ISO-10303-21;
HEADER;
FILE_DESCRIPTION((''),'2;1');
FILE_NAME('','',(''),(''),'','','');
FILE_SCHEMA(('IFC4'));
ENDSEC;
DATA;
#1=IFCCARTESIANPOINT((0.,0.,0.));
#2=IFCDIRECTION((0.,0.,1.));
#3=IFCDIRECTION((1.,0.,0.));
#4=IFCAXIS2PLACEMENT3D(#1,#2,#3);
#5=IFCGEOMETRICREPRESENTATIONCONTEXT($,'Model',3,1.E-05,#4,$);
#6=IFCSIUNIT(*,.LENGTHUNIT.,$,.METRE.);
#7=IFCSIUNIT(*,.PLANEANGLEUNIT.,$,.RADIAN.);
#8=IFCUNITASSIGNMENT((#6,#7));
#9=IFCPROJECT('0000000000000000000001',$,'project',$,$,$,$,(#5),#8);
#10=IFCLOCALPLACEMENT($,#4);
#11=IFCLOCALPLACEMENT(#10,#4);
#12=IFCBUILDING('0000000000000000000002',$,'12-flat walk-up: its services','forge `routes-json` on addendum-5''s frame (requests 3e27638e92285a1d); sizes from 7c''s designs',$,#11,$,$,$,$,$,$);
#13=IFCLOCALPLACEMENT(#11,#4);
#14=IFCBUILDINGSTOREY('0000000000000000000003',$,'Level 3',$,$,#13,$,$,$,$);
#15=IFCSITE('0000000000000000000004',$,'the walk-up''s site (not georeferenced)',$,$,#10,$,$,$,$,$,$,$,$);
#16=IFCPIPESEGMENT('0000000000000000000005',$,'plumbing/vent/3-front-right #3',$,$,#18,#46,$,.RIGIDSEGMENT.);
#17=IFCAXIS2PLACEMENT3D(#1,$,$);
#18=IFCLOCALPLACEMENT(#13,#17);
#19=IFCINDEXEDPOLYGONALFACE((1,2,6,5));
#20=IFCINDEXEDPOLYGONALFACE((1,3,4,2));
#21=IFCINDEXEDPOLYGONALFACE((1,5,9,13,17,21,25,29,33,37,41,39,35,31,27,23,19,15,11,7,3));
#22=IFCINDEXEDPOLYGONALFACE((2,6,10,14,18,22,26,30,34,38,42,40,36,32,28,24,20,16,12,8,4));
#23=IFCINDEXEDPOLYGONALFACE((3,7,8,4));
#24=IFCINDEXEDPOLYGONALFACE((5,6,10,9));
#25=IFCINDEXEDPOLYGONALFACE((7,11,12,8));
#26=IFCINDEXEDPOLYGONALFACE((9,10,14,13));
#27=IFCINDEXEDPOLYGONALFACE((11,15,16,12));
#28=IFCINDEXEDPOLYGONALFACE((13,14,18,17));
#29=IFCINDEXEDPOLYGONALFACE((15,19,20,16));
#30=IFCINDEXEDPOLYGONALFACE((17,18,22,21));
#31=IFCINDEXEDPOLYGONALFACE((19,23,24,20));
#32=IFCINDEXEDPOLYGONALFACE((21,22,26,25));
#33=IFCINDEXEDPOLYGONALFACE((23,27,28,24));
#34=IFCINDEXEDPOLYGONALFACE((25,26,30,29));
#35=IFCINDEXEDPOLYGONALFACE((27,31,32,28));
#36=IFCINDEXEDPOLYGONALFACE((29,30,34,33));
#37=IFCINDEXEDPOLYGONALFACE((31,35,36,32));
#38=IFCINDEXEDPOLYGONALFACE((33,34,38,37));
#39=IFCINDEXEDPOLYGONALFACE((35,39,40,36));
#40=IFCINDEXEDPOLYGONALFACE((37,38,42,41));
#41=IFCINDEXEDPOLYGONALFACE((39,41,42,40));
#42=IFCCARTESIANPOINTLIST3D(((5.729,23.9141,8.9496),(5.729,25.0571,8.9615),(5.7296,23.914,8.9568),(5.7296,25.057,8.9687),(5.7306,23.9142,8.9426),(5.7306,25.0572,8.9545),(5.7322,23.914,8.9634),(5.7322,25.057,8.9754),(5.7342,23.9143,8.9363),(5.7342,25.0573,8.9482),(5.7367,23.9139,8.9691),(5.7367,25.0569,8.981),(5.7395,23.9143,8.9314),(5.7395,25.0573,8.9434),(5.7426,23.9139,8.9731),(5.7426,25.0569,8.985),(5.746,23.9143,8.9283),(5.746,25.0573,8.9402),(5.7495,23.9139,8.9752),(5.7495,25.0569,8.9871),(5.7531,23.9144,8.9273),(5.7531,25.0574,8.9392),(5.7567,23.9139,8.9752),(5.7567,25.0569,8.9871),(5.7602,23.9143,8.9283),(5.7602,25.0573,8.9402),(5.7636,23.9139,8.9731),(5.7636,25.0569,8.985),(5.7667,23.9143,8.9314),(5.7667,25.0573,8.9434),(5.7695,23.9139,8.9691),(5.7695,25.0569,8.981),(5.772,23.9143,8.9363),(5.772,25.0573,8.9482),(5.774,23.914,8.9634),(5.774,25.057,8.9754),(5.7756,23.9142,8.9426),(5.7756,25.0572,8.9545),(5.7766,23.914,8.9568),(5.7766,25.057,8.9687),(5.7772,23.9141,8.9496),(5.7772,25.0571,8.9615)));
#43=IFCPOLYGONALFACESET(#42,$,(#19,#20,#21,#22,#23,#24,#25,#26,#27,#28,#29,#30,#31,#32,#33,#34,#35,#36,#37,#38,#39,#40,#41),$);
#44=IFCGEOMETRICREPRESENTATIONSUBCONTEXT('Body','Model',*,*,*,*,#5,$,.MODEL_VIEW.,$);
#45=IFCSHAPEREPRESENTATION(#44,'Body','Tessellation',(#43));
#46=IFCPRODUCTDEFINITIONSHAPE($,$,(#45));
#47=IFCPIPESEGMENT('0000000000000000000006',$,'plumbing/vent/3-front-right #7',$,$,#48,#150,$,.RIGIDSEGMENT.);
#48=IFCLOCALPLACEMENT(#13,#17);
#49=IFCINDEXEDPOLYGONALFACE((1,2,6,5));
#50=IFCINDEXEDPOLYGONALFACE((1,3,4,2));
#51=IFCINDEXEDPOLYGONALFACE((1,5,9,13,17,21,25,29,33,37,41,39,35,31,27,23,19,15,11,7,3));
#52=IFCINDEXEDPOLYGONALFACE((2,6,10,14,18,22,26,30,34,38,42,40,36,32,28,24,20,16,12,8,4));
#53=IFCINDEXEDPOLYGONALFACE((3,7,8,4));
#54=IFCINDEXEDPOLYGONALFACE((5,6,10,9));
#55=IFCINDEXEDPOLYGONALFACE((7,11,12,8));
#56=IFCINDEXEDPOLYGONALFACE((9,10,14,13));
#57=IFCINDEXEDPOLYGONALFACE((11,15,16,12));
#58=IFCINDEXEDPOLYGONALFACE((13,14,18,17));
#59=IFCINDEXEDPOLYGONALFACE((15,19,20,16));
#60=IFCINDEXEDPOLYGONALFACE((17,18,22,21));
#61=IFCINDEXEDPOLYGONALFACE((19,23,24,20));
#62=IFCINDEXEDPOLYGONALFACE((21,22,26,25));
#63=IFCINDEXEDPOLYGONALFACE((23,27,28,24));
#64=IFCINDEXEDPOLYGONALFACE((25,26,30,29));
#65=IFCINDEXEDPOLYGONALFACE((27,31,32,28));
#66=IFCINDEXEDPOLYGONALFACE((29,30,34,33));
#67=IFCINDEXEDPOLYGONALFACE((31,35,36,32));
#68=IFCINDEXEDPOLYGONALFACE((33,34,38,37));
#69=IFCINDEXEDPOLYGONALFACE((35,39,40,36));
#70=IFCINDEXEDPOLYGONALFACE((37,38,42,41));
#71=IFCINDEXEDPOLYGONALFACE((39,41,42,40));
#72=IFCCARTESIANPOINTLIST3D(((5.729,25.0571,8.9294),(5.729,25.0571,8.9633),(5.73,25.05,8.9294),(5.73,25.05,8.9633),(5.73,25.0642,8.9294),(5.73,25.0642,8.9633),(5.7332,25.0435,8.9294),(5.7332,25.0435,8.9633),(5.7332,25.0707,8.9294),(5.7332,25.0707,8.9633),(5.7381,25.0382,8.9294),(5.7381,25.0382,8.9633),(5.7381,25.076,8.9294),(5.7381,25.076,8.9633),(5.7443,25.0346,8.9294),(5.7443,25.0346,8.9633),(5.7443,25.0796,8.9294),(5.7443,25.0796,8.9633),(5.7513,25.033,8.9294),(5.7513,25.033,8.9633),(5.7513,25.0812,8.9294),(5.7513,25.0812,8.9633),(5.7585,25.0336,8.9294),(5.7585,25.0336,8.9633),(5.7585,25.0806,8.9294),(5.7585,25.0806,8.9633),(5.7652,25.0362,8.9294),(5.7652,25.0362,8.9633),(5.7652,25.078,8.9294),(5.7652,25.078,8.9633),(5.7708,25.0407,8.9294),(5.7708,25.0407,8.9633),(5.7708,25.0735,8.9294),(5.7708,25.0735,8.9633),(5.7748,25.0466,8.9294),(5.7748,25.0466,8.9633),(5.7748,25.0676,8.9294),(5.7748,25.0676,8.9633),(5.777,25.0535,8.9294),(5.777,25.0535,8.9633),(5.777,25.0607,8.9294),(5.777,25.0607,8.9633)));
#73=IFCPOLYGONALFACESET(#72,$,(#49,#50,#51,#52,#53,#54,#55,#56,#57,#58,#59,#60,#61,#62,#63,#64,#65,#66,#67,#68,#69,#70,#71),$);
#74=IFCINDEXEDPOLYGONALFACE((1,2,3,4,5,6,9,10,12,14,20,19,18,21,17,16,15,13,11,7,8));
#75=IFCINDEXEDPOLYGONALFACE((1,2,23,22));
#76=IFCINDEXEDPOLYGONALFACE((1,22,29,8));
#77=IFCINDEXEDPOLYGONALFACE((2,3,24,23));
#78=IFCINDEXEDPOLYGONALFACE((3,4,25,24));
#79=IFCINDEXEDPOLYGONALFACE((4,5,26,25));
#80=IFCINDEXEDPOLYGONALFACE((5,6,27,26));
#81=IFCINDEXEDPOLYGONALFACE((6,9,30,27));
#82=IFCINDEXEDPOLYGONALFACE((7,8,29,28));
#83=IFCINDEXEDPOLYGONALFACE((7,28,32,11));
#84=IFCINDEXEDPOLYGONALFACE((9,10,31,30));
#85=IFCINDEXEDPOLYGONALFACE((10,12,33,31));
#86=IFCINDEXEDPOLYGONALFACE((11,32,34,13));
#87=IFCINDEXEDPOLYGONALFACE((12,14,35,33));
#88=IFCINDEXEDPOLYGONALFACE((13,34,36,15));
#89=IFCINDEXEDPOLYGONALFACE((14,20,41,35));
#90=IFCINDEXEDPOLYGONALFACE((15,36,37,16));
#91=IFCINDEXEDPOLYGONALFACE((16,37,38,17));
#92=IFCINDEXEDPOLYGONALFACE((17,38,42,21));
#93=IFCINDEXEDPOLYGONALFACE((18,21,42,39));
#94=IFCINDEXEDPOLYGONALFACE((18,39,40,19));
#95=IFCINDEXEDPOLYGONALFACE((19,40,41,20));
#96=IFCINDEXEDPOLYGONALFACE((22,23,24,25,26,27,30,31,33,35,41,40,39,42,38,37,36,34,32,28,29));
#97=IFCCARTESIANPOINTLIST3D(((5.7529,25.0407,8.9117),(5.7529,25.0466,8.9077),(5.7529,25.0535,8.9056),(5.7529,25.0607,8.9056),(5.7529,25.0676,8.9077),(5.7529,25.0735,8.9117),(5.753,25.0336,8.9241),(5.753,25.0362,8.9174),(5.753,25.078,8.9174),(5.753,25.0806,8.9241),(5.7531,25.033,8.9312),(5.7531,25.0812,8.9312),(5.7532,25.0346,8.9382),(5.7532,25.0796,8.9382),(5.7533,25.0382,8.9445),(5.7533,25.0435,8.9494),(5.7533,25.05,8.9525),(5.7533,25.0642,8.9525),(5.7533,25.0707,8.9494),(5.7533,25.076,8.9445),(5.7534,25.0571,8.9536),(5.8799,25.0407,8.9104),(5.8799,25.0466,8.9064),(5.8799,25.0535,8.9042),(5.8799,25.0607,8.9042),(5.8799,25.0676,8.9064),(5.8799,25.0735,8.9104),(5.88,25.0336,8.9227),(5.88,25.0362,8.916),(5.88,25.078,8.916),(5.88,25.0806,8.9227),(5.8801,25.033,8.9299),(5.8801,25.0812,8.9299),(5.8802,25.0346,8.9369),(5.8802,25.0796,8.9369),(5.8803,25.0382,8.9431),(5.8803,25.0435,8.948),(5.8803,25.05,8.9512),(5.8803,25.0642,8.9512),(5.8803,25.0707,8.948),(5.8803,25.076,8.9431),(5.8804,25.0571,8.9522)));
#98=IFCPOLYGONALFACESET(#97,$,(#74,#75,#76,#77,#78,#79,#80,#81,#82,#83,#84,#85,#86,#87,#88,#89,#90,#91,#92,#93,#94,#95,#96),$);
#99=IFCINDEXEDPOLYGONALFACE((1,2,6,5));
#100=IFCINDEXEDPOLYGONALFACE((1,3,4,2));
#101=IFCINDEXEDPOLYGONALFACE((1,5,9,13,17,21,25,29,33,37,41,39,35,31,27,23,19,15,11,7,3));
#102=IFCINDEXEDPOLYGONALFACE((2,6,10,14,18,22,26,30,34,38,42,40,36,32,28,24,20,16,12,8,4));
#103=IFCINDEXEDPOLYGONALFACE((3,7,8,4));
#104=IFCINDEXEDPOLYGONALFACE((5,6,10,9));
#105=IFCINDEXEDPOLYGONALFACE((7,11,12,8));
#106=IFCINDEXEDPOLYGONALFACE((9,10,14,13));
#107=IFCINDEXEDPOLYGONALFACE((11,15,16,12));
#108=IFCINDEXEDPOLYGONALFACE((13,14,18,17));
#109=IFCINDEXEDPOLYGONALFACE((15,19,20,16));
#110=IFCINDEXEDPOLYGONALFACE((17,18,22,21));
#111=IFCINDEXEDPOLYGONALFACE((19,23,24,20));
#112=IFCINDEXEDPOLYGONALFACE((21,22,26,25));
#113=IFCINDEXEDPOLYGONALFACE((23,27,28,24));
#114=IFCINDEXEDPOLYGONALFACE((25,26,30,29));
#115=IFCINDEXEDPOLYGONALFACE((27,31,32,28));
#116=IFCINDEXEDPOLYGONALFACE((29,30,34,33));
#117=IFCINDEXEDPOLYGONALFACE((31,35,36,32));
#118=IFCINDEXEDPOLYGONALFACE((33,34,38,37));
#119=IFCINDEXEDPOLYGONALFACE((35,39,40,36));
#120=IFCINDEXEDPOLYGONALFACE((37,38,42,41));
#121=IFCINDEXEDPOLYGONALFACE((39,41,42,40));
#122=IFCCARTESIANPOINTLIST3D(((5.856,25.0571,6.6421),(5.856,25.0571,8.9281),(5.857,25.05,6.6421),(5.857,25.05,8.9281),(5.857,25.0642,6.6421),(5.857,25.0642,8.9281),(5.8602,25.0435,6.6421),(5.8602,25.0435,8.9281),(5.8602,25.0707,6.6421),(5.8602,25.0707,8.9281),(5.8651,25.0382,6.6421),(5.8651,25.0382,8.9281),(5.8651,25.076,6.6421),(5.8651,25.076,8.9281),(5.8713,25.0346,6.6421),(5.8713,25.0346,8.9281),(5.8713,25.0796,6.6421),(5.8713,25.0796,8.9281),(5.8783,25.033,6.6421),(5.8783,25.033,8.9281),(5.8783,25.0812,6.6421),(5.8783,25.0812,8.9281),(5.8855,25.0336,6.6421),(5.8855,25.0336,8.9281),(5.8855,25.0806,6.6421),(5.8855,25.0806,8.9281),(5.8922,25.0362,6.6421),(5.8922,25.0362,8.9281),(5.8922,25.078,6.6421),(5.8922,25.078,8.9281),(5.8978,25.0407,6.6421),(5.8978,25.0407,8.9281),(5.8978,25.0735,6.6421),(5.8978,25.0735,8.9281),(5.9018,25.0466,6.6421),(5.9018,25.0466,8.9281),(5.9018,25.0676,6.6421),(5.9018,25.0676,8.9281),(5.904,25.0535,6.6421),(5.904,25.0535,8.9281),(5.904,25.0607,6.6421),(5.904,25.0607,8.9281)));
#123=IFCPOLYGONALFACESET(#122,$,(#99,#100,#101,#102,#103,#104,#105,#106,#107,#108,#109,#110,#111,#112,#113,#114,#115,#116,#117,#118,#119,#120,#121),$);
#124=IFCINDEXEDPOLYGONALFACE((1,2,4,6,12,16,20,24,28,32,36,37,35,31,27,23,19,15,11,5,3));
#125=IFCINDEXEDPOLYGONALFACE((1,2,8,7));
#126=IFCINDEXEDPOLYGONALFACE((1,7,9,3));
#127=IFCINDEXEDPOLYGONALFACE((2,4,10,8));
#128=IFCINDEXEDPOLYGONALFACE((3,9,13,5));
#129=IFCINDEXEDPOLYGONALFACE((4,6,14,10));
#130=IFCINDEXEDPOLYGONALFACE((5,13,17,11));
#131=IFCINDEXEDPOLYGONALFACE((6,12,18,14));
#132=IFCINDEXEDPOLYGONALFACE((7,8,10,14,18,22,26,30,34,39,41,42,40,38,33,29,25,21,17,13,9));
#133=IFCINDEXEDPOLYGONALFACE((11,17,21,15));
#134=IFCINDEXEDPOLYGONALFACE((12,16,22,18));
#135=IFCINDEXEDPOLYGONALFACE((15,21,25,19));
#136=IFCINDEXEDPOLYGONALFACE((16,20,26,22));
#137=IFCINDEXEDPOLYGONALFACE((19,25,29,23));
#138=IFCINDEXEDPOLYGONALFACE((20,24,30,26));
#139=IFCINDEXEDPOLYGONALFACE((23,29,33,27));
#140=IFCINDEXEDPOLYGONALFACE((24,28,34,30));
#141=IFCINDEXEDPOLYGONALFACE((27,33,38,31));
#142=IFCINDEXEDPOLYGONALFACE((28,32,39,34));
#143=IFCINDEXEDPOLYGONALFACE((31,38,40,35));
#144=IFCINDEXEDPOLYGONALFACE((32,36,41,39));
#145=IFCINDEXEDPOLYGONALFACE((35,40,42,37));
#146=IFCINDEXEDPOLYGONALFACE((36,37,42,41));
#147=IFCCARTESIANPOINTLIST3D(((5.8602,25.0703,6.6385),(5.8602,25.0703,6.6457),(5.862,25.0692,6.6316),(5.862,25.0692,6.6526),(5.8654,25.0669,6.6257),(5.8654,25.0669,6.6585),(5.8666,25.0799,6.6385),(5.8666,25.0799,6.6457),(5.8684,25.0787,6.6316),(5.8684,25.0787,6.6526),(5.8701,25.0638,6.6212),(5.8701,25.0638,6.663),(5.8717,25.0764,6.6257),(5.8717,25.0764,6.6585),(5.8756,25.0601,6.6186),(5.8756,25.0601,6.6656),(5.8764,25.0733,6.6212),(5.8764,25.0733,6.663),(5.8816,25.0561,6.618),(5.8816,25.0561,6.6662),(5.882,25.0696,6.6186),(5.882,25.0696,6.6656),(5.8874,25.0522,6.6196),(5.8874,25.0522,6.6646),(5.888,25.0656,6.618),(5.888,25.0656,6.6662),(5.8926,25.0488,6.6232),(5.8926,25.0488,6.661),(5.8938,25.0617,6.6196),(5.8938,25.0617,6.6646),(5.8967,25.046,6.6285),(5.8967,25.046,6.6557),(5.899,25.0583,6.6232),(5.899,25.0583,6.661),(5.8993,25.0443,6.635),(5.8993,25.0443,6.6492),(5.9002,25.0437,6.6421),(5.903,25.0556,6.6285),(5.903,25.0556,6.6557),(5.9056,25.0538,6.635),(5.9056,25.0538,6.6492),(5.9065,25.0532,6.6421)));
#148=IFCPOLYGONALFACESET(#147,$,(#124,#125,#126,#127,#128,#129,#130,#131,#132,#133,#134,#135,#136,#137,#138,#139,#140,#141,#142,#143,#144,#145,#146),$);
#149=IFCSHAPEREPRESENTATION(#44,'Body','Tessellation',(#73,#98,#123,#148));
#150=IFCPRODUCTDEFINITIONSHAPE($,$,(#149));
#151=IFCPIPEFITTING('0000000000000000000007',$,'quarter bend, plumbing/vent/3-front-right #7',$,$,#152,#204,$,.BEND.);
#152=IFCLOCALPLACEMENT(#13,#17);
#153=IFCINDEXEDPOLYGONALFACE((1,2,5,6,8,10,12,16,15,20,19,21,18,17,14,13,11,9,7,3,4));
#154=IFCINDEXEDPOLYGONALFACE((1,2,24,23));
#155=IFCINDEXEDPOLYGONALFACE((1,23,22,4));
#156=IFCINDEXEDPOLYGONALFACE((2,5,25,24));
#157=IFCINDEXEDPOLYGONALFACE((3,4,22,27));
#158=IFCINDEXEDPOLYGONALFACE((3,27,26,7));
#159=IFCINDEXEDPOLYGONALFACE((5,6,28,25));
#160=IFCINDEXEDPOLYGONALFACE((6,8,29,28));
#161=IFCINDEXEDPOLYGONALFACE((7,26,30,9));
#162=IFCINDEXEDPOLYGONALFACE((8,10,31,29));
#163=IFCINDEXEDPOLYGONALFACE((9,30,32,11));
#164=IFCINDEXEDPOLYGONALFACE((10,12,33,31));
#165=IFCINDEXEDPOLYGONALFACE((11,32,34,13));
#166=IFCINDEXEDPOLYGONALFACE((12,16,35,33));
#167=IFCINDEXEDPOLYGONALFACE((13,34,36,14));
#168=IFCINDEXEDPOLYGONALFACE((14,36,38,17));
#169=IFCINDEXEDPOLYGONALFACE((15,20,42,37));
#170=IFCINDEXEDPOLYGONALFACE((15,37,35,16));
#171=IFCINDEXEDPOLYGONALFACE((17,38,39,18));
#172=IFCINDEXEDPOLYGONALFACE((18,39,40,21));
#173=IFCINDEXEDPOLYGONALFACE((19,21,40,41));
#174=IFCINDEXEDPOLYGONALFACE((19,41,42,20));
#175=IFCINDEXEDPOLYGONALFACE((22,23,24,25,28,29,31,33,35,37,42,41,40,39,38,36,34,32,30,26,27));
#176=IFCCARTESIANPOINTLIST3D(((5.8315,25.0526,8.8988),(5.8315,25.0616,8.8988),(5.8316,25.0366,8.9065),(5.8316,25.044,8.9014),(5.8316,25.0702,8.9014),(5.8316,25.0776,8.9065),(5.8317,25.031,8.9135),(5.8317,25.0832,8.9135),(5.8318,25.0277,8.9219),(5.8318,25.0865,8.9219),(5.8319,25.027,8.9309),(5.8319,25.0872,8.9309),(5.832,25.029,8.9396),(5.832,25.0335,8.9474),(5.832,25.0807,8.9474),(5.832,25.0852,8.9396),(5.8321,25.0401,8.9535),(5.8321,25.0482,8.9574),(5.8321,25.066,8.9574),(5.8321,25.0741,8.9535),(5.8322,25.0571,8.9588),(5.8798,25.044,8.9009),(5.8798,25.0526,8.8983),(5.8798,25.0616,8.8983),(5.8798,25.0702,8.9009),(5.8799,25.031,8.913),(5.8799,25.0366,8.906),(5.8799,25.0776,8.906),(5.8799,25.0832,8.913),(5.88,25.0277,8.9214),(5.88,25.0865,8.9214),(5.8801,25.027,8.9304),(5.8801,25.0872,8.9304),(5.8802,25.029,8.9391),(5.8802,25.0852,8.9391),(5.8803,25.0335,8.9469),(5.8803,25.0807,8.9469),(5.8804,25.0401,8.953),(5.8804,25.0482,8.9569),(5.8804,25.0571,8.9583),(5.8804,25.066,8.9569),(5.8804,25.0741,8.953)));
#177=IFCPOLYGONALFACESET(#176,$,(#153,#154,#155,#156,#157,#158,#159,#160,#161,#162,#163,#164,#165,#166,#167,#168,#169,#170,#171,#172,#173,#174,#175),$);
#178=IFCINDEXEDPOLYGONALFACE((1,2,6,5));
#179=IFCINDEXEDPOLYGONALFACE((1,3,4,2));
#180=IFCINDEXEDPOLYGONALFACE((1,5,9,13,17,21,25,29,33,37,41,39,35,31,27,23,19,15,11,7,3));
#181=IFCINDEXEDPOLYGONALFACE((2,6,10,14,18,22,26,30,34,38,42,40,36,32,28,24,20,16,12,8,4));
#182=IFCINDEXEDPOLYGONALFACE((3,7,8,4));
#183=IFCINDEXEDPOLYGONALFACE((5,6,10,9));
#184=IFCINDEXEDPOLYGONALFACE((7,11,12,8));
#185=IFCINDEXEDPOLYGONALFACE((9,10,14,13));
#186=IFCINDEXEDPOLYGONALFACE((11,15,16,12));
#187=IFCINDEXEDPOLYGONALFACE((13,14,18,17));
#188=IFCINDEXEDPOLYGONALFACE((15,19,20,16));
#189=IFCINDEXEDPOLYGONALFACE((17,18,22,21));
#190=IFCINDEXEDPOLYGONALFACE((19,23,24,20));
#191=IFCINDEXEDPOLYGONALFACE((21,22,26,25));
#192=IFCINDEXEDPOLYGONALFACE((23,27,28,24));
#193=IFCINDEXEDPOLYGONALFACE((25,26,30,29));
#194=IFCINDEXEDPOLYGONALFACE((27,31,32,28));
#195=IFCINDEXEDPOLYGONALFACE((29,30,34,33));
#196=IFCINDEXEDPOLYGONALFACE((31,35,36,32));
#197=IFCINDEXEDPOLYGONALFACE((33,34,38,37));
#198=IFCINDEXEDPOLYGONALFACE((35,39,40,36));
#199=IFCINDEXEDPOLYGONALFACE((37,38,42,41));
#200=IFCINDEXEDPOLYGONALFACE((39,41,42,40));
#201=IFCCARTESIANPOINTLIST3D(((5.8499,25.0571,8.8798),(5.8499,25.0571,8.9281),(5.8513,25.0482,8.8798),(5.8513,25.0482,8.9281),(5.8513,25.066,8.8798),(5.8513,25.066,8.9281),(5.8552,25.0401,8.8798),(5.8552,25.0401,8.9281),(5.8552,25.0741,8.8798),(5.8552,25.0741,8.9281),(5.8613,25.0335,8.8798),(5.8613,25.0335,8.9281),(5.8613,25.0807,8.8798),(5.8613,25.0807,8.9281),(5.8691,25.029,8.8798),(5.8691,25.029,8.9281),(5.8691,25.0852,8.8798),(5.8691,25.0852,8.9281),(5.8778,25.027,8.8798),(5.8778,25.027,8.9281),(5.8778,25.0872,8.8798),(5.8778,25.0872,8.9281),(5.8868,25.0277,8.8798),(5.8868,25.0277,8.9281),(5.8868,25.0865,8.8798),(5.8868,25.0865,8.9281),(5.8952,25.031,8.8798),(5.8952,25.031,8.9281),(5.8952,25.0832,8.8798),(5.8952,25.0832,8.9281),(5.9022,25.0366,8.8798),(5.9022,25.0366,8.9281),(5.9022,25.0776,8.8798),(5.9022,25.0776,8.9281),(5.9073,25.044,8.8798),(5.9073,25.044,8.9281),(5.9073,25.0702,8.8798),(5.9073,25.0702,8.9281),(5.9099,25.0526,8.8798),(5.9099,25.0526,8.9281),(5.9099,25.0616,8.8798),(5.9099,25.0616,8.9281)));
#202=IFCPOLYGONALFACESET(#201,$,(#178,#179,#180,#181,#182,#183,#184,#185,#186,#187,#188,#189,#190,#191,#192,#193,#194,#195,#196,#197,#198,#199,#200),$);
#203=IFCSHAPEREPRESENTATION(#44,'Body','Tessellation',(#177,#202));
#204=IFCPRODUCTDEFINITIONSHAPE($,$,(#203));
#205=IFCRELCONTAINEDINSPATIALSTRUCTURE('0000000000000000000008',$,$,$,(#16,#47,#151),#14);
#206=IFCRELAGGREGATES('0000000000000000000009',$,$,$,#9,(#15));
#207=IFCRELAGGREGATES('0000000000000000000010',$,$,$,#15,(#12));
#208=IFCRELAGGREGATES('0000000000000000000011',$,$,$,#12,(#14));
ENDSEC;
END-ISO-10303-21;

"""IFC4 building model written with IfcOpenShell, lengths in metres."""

from ifc_helpers import new_model, entity, si_unit, frame, origin_with_axes, place, context, subcontext, project, spatial, element, save


model = new_model("IFC4")

# Units and contexts
model_context = context("Model", 3, precision=1e-05, world=origin_with_axes())
body_context = subcontext(model_context, "Body", "Model", "MODEL_VIEW")
ifc_project = project(units=[si_unit("LENGTHUNIT", "METRE"), si_unit("PLANEANGLEUNIT", "RADIAN")], contexts=[model_context])

# Site, building, storey
site_placement = place(None, origin_with_axes())
site = spatial("IfcSite", under=ifc_project, at=site_placement, Name="the walk-up's site (not georeferenced)")
building_placement = place(site_placement, origin_with_axes())
building = spatial("IfcBuilding", under=site, at=building_placement, Name="12-flat walk-up: its services", Description="forge `routes-json` on addendum-5's frame (requests 3e27638e92285a1d); sizes from 7c's designs")
storey_placement = place(building_placement, origin_with_axes())
storey = spatial("IfcBuildingStorey", under=building, at=storey_placement, Name="Level 3")

# Pipe segments
pipe_segment_1_placement = place(storey_placement, frame((5.7531, 25.0571, 8.9633), z_axis=(0.0, 0.0, 1.0), x_axis=(1.0, 0.0, 0.0)))
element("IfcPipeSegment", 1, at=pipe_segment_1_placement, inside=storey, Name="plumbing/vent/3-front-right #3", PredefinedType="RIGIDSEGMENT", context=body_context, shape_type="AdvancedSweptSolid", body=[
    entity("IfcSweptDiskSolid", entity("IfcPolyline", [entity("IfcCartesianPoint", [0.0, 0.0, 0.0]), entity("IfcCartesianPoint", [0.0, -1.143, -0.0119])]), 0.0241),
])
pipe_segment_2_placement = place(storey_placement, frame((5.7531, 25.0571, 8.9633), z_axis=(0.0, 0.0, 1.0), x_axis=(1.0, 0.0, 0.0)))
element("IfcPipeSegment", 2, at=pipe_segment_2_placement, inside=storey, Name="plumbing/vent/3-front-right #7", PredefinedType="RIGIDSEGMENT", context=body_context, shape_type="AdvancedSweptSolid", body=[
    entity("IfcSweptDiskSolid", entity("IfcPolyline", [entity("IfcCartesianPoint", [0.0, 0.0, 0.0]), entity("IfcCartesianPoint", [0.0, 0.0, -0.0339])]), 0.0241),
    entity("IfcSweptDiskSolid", entity("IfcPolyline", [entity("IfcCartesianPoint", [0.0, 0.0, -0.0339]), entity("IfcCartesianPoint", [0.127, 0.0, -0.0352])]), 0.0241),
    entity("IfcSweptDiskSolid", entity("IfcPolyline", [entity("IfcCartesianPoint", [0.127, 0.0, -0.0352]), entity("IfcCartesianPoint", [0.127, 0.0, -2.3212])]), 0.0241),
    entity("IfcSweptDiskSolid", entity("IfcPolyline", [entity("IfcCartesianPoint", [0.127, 0.0, -2.3212]), entity("IfcCartesianPoint", [0.1334, 0.0095, -2.3212])]), 0.0241),
])

# Pipe fitting
pipe_fitting_1_placement = place(storey_placement, frame((5.8318, 25.0571, 8.9286), z_axis=(0.0, 0.0, 1.0), x_axis=(1.0, 0.0, 0.0)))
element("IfcPipeFitting", 3, at=pipe_fitting_1_placement, inside=storey, Name="quarter bend, plumbing/vent/3-front-right #7", PredefinedType="BEND", context=body_context, shape_type="AdvancedSweptSolid", body=[
    entity("IfcSweptDiskSolid", entity("IfcPolyline", [entity("IfcCartesianPoint", [0.0, 0.0, 0.0]), entity("IfcCartesianPoint", [0.0483, 0.0, -0.0005])]), 0.0302),
    entity("IfcSweptDiskSolid", entity("IfcPolyline", [entity("IfcCartesianPoint", [0.0483, 0.0, -0.0005]), entity("IfcCartesianPoint", [0.0483, 0.0, -0.0488])]), 0.0302),
])

save(model, "model.ifc")
